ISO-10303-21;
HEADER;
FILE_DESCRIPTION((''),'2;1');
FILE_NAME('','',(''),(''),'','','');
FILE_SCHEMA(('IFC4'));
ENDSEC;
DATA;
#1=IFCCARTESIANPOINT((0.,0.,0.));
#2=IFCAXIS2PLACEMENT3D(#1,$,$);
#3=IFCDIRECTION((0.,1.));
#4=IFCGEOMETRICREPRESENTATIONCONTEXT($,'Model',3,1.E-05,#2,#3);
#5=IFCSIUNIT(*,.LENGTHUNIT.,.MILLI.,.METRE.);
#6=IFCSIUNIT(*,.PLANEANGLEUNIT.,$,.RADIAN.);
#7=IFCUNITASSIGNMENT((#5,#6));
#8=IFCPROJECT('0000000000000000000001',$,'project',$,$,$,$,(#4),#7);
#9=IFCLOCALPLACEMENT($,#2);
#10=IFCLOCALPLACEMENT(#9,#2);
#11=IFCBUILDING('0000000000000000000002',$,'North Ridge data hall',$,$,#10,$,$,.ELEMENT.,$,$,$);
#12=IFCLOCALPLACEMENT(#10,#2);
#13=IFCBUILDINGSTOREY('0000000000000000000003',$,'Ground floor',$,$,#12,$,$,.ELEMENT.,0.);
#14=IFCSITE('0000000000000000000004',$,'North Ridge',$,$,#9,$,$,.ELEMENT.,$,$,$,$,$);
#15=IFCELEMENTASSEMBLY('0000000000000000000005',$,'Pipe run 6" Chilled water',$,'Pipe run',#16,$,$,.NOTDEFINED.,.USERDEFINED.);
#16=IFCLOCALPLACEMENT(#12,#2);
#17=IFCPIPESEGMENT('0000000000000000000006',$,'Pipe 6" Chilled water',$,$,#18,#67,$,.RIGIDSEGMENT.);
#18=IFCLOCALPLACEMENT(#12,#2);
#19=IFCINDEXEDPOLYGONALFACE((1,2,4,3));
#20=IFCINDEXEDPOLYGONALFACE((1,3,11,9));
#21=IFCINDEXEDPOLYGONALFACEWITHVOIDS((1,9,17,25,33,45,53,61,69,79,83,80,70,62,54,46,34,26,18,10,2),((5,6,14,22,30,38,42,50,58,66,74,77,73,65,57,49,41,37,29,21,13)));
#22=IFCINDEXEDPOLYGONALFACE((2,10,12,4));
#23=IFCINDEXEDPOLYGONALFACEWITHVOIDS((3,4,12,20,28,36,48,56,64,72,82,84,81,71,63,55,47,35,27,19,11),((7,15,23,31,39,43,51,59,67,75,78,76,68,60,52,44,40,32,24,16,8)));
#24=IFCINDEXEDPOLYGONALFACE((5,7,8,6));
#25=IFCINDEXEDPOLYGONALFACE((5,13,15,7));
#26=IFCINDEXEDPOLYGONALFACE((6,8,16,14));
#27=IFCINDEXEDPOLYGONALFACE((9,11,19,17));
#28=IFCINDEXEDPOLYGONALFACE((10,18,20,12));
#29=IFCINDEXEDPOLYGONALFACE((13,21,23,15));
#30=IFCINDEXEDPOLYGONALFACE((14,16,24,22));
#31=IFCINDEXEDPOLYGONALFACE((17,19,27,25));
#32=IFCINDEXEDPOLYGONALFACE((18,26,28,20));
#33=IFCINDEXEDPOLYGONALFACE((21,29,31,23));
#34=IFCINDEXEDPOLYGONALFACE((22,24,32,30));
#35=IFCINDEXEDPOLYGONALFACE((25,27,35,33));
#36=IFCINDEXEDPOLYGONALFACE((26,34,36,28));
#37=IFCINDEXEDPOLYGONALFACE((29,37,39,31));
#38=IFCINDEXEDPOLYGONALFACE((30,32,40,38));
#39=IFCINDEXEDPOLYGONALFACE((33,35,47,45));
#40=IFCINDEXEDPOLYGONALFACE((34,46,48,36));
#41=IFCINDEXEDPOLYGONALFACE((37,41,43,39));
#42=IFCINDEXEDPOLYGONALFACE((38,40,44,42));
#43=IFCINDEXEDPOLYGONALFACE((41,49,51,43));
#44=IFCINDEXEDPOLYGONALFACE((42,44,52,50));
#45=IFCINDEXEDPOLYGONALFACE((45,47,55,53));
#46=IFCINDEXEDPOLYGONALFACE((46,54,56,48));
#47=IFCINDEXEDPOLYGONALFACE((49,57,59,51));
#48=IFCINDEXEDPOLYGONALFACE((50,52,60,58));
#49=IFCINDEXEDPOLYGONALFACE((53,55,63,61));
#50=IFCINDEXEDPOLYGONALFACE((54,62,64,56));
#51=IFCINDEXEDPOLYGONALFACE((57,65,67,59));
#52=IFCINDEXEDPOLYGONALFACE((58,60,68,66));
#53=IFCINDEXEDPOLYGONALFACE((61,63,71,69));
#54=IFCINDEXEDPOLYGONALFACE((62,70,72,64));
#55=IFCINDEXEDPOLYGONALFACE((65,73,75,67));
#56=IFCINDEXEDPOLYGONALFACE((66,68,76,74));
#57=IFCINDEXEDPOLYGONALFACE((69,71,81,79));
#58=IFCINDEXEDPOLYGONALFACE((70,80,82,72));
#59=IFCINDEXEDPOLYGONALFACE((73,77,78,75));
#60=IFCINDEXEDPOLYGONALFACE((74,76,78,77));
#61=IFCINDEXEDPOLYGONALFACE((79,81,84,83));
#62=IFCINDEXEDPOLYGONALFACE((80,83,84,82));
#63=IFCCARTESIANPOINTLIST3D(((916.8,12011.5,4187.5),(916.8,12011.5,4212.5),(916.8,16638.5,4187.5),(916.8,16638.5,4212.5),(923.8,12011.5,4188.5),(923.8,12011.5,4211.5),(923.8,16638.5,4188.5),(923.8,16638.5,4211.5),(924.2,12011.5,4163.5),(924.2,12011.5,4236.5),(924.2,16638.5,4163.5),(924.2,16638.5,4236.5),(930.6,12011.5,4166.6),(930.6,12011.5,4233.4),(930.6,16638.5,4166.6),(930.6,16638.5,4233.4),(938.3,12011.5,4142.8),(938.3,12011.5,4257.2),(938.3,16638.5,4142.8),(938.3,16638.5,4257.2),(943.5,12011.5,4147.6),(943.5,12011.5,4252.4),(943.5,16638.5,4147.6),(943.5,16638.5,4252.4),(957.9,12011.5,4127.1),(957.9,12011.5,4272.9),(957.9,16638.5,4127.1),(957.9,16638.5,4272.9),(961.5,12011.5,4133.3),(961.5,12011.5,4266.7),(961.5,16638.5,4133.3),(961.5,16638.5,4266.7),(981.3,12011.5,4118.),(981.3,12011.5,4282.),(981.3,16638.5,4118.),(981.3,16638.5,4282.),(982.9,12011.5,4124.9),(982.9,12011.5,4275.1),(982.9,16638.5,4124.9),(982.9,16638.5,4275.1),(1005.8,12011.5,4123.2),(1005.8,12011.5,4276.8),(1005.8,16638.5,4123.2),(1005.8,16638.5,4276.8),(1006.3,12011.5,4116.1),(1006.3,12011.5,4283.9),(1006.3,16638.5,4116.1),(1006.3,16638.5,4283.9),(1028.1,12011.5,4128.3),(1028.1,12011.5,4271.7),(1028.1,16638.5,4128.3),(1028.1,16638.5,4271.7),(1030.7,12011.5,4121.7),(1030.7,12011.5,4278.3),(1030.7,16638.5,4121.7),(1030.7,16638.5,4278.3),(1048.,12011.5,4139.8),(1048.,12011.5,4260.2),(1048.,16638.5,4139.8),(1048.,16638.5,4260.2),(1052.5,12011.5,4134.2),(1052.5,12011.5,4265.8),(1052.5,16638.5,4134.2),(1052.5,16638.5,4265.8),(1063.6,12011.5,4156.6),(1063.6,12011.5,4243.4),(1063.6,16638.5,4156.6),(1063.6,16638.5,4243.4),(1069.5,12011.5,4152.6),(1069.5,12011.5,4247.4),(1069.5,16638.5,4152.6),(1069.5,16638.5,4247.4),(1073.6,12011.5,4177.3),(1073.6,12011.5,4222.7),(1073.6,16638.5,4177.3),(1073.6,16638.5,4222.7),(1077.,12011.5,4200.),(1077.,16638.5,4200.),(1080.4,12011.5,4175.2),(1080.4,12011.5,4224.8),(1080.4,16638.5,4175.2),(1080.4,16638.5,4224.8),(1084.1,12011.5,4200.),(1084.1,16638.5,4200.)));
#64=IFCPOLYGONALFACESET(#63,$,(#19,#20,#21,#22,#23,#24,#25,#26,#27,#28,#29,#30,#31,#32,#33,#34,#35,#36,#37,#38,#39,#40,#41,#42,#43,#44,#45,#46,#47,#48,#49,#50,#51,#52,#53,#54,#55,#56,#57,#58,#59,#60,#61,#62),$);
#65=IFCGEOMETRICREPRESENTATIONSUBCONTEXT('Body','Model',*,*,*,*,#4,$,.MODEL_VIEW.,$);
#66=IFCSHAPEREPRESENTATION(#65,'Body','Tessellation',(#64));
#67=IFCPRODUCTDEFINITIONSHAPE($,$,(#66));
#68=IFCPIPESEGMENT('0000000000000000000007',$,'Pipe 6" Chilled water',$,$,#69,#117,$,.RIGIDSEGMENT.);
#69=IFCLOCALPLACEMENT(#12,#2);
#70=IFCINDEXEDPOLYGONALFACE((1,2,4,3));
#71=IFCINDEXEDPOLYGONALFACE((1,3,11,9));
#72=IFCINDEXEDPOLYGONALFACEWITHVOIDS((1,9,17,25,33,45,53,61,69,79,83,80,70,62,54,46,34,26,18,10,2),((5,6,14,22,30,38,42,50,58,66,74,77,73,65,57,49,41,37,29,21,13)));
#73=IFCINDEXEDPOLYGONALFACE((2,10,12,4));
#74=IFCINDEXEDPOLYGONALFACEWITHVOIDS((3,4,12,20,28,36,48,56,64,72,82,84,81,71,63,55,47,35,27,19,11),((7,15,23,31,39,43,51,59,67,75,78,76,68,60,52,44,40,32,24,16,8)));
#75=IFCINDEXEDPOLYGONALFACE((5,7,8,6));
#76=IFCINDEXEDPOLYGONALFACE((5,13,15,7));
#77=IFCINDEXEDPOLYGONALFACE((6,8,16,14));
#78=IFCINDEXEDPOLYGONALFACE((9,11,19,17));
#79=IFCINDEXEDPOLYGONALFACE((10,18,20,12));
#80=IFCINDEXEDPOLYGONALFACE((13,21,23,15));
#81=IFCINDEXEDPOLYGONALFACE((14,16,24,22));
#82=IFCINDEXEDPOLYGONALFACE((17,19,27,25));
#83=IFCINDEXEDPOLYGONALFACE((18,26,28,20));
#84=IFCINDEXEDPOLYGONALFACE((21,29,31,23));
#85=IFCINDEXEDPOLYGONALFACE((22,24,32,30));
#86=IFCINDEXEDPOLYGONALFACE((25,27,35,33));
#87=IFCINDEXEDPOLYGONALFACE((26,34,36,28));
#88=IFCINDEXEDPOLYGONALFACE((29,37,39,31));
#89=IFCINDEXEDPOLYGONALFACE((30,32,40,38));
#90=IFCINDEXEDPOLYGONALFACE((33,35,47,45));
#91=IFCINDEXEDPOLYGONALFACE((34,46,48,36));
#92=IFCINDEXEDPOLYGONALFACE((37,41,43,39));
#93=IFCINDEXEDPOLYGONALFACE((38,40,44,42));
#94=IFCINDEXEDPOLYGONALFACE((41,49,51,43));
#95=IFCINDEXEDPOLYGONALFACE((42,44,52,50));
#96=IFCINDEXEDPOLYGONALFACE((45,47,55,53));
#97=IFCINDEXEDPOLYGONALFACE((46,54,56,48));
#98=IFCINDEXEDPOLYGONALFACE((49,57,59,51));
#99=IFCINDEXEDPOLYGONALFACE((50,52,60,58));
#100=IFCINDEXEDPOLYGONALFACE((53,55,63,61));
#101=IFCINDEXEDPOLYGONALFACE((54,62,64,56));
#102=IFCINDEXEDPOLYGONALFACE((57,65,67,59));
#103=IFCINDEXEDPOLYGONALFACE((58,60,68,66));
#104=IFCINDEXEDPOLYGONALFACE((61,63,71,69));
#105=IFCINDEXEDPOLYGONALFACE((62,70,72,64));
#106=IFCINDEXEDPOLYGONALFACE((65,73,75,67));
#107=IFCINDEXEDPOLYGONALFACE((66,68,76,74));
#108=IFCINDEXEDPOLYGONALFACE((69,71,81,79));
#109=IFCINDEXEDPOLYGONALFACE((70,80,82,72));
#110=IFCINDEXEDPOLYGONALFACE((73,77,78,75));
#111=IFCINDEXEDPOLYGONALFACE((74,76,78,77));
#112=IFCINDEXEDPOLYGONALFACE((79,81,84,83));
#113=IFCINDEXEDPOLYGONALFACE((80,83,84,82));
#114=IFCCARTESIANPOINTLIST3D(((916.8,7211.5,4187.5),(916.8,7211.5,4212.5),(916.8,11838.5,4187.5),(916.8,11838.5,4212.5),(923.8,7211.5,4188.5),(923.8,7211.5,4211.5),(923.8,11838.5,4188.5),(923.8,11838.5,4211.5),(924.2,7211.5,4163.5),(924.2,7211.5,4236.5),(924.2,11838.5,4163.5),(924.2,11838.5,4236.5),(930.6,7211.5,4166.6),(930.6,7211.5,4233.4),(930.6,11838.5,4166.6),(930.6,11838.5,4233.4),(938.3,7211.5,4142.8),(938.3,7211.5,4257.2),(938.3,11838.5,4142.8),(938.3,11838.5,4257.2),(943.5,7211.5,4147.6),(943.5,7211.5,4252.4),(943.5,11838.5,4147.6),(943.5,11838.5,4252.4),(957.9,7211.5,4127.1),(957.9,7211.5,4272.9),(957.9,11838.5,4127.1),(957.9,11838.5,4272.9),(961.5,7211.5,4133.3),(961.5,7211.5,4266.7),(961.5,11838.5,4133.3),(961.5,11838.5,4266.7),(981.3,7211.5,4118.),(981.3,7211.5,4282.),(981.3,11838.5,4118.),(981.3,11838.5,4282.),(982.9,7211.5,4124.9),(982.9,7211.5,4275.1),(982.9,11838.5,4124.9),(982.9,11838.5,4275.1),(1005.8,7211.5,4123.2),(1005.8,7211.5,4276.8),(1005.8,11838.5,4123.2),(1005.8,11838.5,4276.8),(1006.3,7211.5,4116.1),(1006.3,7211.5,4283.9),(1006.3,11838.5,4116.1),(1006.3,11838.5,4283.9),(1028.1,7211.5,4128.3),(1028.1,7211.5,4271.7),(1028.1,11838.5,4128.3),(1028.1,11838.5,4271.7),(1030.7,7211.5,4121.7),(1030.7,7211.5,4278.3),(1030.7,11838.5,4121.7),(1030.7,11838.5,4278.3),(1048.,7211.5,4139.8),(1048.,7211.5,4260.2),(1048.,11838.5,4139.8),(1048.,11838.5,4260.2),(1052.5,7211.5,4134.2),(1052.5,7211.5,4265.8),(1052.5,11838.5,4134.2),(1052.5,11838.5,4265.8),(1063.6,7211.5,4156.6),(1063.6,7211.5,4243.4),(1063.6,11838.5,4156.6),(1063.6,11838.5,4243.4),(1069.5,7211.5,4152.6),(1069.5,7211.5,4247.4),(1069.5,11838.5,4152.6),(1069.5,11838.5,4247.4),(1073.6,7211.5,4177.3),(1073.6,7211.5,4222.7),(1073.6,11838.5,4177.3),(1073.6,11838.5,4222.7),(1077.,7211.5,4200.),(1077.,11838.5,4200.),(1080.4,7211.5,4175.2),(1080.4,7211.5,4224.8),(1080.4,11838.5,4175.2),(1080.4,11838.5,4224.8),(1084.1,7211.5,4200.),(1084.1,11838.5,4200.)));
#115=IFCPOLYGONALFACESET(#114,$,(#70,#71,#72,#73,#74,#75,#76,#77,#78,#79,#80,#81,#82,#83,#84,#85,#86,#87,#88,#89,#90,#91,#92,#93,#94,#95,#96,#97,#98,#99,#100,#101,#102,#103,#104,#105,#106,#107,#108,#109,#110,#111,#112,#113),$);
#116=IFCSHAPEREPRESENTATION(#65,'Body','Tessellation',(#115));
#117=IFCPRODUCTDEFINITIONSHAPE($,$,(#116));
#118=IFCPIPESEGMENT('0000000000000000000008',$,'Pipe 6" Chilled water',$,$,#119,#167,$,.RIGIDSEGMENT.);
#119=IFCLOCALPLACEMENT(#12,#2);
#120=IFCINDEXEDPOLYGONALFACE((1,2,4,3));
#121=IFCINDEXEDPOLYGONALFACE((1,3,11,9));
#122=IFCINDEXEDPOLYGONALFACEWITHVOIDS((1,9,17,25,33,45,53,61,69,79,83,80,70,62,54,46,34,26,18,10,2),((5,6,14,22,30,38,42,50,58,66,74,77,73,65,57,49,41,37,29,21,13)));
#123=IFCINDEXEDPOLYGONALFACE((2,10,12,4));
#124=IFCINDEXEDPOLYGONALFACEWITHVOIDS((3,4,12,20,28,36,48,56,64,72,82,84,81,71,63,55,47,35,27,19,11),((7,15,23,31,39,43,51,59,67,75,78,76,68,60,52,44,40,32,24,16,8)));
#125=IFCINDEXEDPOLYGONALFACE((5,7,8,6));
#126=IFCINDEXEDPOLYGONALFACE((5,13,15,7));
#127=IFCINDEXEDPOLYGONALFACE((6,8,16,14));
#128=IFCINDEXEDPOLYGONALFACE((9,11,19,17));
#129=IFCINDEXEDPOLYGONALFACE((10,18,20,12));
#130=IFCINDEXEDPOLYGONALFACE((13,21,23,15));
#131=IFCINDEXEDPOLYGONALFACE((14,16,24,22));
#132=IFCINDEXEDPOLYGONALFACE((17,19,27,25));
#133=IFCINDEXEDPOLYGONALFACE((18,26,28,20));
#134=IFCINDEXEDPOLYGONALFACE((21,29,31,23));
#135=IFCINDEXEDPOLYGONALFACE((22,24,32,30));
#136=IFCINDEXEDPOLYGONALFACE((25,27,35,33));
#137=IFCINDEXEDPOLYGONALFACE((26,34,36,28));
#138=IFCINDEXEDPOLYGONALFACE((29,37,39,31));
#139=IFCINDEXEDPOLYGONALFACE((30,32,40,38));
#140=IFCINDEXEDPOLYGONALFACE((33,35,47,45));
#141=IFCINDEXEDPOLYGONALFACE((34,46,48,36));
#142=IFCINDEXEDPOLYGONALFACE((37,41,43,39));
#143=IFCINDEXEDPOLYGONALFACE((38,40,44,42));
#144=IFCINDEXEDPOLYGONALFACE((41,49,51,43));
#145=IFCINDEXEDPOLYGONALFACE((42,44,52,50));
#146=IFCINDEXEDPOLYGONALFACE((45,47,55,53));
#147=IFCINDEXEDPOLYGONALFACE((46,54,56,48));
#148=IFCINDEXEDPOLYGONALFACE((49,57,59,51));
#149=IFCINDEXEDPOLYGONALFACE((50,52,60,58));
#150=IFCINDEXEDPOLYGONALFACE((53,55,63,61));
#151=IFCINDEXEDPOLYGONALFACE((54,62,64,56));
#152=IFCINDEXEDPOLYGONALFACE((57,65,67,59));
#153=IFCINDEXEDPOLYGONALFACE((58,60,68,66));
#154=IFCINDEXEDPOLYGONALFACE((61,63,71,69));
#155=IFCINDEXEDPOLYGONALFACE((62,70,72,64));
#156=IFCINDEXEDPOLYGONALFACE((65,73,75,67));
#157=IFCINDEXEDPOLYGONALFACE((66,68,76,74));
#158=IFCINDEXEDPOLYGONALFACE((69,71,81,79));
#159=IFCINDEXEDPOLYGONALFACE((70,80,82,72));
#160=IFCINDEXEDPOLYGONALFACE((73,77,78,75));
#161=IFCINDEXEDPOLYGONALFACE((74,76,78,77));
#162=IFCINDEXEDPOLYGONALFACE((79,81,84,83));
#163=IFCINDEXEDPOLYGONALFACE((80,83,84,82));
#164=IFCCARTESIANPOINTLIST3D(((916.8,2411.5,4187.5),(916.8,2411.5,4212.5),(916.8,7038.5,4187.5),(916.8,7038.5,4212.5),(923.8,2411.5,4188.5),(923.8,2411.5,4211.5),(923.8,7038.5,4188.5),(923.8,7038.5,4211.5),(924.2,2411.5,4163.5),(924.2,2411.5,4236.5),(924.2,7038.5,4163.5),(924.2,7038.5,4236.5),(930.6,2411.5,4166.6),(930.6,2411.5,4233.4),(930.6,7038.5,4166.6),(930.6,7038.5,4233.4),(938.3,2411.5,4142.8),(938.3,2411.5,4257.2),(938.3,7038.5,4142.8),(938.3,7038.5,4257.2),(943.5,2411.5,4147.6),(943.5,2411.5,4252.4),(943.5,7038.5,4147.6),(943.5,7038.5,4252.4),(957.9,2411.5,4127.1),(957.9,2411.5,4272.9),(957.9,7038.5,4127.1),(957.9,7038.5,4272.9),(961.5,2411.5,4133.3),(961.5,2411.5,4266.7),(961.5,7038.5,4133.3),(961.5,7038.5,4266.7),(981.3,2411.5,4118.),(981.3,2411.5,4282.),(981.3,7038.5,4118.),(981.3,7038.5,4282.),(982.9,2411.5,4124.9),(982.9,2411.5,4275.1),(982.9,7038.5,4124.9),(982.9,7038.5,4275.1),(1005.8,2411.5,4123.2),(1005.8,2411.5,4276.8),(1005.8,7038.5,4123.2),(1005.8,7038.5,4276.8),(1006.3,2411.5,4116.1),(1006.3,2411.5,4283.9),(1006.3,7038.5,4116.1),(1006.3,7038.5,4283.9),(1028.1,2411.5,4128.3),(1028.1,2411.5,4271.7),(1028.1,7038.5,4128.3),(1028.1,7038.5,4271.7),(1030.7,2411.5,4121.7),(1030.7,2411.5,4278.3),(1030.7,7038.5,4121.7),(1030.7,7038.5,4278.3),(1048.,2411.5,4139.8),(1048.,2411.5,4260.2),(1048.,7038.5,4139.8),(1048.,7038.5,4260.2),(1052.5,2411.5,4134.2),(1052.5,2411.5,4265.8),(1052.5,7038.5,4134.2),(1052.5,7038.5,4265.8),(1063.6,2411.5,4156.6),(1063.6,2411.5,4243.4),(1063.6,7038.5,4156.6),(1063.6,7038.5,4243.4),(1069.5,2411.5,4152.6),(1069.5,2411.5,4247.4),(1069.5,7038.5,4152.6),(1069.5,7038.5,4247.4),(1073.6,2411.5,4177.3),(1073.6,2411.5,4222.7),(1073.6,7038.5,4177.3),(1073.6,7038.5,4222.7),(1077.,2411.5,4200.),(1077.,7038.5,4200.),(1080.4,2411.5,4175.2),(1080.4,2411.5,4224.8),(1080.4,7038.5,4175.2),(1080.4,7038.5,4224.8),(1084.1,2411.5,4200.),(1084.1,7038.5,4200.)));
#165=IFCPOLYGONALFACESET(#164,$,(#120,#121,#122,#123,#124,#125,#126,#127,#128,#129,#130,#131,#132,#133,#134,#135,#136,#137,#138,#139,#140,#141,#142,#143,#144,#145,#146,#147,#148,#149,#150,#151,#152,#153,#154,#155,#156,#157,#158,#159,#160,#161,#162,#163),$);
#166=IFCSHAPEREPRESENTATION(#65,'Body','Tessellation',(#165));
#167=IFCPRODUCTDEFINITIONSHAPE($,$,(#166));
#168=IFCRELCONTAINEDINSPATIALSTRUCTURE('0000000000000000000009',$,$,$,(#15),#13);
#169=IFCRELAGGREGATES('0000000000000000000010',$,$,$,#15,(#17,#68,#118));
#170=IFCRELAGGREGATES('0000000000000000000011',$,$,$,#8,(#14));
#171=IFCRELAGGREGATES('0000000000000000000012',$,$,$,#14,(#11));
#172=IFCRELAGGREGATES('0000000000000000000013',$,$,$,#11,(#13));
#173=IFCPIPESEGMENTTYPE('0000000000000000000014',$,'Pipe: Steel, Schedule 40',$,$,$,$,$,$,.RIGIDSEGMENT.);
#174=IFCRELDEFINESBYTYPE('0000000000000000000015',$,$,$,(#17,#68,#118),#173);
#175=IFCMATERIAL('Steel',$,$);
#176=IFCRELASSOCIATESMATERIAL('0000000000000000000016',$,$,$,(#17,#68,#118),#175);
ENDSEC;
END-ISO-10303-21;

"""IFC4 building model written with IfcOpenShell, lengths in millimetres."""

from ifc_helpers import new_model, si_unit, direction, frame, origin, origin_with_axes, origin_2d, place, context, subcontext, project, spatial, hollow_circle, extrude, material, type_object, element, aggregate, save


model = new_model("IFC4")

# Units and contexts
model_context = context("Model", 3, precision=1e-05, world=origin(), true_north=direction((0.0, 1.0)))
body_context = subcontext(model_context, "Body", "Model", "MODEL_VIEW")
ifc_project = project(units=[si_unit("LENGTHUNIT", "METRE", prefix="MILLI"), si_unit("PLANEANGLEUNIT", "RADIAN")], contexts=[model_context])

# Site, building, storey
site_placement = place(None, origin())
site = spatial("IfcSite", under=ifc_project, at=site_placement, Name="North Ridge", CompositionType="ELEMENT")
building_placement = place(site_placement, origin())
building = spatial("IfcBuilding", under=site, at=building_placement, Name="North Ridge data hall", CompositionType="ELEMENT")
storey_placement = place(building_placement, origin())
storey = spatial("IfcBuildingStorey", under=building, at=storey_placement, Name="Ground floor", CompositionType="ELEMENT", Elevation=0.0)

# Element assembly, pipe segments
assembly_1_placement = place(storey_placement, origin_with_axes())
assembly_1 = element("IfcElementAssembly", 1, at=assembly_1_placement, inside=storey, Name="Pipe run 6\" Chilled water", ObjectType="Pipe run", AssemblyPlace="NOTDEFINED", PredefinedType="USERDEFINED")
ifc_material_1 = material(Name="Steel")
pipe_segment_type = type_object("IfcPipeSegmentType", Name="Pipe: Steel, Schedule 40", PredefinedType="RIGIDSEGMENT")
pipe_segment_1_placement = place(storey_placement, origin_with_axes())
pipe_segment_1 = element("IfcPipeSegment", 2, at=pipe_segment_1_placement, type_object=pipe_segment_type, material=ifc_material_1, Name="Pipe 6\" Chilled water", PredefinedType="RIGIDSEGMENT", context=body_context, shape_type="SweptSolid", body=[
    extrude(hollow_circle(Radius=84.1, WallThickness=7.1, at=origin_2d()), frame((1000.0, 16638.5, 4200.0), z_axis=(0.0, -1.0, 0.0), x_axis=(1.0, 0.0, 0.0)), (0.0, 0.0, 1.0), 4627.0),
])
pipe_segment_2_placement = place(storey_placement, origin_with_axes())
pipe_segment_2 = element("IfcPipeSegment", 3, at=pipe_segment_2_placement, type_object=pipe_segment_type, material=ifc_material_1, Name="Pipe 6\" Chilled water", PredefinedType="RIGIDSEGMENT", context=body_context, shape_type="SweptSolid", body=[
    extrude(hollow_circle(Radius=84.1, WallThickness=7.1, at=origin_2d()), frame((1000.0, 11838.5, 4200.0), z_axis=(0.0, -1.0, 0.0), x_axis=(1.0, 0.0, 0.0)), (0.0, 0.0, 1.0), 4627.0),
])
pipe_segment_3_placement = place(storey_placement, origin_with_axes())
pipe_segment_3 = element("IfcPipeSegment", 4, at=pipe_segment_3_placement, type_object=pipe_segment_type, material=ifc_material_1, Name="Pipe 6\" Chilled water", PredefinedType="RIGIDSEGMENT", context=body_context, shape_type="SweptSolid", body=[
    extrude(hollow_circle(Radius=84.1, WallThickness=7.1, at=origin_2d()), frame((1000.0, 7038.5, 4200.0), z_axis=(0.0, -1.0, 0.0), x_axis=(1.0, 0.0, 0.0)), (0.0, 0.0, 1.0), 4627.0),
])

aggregate(assembly_1, [pipe_segment_1, pipe_segment_2, pipe_segment_3])

save(model, "model.ifc")
